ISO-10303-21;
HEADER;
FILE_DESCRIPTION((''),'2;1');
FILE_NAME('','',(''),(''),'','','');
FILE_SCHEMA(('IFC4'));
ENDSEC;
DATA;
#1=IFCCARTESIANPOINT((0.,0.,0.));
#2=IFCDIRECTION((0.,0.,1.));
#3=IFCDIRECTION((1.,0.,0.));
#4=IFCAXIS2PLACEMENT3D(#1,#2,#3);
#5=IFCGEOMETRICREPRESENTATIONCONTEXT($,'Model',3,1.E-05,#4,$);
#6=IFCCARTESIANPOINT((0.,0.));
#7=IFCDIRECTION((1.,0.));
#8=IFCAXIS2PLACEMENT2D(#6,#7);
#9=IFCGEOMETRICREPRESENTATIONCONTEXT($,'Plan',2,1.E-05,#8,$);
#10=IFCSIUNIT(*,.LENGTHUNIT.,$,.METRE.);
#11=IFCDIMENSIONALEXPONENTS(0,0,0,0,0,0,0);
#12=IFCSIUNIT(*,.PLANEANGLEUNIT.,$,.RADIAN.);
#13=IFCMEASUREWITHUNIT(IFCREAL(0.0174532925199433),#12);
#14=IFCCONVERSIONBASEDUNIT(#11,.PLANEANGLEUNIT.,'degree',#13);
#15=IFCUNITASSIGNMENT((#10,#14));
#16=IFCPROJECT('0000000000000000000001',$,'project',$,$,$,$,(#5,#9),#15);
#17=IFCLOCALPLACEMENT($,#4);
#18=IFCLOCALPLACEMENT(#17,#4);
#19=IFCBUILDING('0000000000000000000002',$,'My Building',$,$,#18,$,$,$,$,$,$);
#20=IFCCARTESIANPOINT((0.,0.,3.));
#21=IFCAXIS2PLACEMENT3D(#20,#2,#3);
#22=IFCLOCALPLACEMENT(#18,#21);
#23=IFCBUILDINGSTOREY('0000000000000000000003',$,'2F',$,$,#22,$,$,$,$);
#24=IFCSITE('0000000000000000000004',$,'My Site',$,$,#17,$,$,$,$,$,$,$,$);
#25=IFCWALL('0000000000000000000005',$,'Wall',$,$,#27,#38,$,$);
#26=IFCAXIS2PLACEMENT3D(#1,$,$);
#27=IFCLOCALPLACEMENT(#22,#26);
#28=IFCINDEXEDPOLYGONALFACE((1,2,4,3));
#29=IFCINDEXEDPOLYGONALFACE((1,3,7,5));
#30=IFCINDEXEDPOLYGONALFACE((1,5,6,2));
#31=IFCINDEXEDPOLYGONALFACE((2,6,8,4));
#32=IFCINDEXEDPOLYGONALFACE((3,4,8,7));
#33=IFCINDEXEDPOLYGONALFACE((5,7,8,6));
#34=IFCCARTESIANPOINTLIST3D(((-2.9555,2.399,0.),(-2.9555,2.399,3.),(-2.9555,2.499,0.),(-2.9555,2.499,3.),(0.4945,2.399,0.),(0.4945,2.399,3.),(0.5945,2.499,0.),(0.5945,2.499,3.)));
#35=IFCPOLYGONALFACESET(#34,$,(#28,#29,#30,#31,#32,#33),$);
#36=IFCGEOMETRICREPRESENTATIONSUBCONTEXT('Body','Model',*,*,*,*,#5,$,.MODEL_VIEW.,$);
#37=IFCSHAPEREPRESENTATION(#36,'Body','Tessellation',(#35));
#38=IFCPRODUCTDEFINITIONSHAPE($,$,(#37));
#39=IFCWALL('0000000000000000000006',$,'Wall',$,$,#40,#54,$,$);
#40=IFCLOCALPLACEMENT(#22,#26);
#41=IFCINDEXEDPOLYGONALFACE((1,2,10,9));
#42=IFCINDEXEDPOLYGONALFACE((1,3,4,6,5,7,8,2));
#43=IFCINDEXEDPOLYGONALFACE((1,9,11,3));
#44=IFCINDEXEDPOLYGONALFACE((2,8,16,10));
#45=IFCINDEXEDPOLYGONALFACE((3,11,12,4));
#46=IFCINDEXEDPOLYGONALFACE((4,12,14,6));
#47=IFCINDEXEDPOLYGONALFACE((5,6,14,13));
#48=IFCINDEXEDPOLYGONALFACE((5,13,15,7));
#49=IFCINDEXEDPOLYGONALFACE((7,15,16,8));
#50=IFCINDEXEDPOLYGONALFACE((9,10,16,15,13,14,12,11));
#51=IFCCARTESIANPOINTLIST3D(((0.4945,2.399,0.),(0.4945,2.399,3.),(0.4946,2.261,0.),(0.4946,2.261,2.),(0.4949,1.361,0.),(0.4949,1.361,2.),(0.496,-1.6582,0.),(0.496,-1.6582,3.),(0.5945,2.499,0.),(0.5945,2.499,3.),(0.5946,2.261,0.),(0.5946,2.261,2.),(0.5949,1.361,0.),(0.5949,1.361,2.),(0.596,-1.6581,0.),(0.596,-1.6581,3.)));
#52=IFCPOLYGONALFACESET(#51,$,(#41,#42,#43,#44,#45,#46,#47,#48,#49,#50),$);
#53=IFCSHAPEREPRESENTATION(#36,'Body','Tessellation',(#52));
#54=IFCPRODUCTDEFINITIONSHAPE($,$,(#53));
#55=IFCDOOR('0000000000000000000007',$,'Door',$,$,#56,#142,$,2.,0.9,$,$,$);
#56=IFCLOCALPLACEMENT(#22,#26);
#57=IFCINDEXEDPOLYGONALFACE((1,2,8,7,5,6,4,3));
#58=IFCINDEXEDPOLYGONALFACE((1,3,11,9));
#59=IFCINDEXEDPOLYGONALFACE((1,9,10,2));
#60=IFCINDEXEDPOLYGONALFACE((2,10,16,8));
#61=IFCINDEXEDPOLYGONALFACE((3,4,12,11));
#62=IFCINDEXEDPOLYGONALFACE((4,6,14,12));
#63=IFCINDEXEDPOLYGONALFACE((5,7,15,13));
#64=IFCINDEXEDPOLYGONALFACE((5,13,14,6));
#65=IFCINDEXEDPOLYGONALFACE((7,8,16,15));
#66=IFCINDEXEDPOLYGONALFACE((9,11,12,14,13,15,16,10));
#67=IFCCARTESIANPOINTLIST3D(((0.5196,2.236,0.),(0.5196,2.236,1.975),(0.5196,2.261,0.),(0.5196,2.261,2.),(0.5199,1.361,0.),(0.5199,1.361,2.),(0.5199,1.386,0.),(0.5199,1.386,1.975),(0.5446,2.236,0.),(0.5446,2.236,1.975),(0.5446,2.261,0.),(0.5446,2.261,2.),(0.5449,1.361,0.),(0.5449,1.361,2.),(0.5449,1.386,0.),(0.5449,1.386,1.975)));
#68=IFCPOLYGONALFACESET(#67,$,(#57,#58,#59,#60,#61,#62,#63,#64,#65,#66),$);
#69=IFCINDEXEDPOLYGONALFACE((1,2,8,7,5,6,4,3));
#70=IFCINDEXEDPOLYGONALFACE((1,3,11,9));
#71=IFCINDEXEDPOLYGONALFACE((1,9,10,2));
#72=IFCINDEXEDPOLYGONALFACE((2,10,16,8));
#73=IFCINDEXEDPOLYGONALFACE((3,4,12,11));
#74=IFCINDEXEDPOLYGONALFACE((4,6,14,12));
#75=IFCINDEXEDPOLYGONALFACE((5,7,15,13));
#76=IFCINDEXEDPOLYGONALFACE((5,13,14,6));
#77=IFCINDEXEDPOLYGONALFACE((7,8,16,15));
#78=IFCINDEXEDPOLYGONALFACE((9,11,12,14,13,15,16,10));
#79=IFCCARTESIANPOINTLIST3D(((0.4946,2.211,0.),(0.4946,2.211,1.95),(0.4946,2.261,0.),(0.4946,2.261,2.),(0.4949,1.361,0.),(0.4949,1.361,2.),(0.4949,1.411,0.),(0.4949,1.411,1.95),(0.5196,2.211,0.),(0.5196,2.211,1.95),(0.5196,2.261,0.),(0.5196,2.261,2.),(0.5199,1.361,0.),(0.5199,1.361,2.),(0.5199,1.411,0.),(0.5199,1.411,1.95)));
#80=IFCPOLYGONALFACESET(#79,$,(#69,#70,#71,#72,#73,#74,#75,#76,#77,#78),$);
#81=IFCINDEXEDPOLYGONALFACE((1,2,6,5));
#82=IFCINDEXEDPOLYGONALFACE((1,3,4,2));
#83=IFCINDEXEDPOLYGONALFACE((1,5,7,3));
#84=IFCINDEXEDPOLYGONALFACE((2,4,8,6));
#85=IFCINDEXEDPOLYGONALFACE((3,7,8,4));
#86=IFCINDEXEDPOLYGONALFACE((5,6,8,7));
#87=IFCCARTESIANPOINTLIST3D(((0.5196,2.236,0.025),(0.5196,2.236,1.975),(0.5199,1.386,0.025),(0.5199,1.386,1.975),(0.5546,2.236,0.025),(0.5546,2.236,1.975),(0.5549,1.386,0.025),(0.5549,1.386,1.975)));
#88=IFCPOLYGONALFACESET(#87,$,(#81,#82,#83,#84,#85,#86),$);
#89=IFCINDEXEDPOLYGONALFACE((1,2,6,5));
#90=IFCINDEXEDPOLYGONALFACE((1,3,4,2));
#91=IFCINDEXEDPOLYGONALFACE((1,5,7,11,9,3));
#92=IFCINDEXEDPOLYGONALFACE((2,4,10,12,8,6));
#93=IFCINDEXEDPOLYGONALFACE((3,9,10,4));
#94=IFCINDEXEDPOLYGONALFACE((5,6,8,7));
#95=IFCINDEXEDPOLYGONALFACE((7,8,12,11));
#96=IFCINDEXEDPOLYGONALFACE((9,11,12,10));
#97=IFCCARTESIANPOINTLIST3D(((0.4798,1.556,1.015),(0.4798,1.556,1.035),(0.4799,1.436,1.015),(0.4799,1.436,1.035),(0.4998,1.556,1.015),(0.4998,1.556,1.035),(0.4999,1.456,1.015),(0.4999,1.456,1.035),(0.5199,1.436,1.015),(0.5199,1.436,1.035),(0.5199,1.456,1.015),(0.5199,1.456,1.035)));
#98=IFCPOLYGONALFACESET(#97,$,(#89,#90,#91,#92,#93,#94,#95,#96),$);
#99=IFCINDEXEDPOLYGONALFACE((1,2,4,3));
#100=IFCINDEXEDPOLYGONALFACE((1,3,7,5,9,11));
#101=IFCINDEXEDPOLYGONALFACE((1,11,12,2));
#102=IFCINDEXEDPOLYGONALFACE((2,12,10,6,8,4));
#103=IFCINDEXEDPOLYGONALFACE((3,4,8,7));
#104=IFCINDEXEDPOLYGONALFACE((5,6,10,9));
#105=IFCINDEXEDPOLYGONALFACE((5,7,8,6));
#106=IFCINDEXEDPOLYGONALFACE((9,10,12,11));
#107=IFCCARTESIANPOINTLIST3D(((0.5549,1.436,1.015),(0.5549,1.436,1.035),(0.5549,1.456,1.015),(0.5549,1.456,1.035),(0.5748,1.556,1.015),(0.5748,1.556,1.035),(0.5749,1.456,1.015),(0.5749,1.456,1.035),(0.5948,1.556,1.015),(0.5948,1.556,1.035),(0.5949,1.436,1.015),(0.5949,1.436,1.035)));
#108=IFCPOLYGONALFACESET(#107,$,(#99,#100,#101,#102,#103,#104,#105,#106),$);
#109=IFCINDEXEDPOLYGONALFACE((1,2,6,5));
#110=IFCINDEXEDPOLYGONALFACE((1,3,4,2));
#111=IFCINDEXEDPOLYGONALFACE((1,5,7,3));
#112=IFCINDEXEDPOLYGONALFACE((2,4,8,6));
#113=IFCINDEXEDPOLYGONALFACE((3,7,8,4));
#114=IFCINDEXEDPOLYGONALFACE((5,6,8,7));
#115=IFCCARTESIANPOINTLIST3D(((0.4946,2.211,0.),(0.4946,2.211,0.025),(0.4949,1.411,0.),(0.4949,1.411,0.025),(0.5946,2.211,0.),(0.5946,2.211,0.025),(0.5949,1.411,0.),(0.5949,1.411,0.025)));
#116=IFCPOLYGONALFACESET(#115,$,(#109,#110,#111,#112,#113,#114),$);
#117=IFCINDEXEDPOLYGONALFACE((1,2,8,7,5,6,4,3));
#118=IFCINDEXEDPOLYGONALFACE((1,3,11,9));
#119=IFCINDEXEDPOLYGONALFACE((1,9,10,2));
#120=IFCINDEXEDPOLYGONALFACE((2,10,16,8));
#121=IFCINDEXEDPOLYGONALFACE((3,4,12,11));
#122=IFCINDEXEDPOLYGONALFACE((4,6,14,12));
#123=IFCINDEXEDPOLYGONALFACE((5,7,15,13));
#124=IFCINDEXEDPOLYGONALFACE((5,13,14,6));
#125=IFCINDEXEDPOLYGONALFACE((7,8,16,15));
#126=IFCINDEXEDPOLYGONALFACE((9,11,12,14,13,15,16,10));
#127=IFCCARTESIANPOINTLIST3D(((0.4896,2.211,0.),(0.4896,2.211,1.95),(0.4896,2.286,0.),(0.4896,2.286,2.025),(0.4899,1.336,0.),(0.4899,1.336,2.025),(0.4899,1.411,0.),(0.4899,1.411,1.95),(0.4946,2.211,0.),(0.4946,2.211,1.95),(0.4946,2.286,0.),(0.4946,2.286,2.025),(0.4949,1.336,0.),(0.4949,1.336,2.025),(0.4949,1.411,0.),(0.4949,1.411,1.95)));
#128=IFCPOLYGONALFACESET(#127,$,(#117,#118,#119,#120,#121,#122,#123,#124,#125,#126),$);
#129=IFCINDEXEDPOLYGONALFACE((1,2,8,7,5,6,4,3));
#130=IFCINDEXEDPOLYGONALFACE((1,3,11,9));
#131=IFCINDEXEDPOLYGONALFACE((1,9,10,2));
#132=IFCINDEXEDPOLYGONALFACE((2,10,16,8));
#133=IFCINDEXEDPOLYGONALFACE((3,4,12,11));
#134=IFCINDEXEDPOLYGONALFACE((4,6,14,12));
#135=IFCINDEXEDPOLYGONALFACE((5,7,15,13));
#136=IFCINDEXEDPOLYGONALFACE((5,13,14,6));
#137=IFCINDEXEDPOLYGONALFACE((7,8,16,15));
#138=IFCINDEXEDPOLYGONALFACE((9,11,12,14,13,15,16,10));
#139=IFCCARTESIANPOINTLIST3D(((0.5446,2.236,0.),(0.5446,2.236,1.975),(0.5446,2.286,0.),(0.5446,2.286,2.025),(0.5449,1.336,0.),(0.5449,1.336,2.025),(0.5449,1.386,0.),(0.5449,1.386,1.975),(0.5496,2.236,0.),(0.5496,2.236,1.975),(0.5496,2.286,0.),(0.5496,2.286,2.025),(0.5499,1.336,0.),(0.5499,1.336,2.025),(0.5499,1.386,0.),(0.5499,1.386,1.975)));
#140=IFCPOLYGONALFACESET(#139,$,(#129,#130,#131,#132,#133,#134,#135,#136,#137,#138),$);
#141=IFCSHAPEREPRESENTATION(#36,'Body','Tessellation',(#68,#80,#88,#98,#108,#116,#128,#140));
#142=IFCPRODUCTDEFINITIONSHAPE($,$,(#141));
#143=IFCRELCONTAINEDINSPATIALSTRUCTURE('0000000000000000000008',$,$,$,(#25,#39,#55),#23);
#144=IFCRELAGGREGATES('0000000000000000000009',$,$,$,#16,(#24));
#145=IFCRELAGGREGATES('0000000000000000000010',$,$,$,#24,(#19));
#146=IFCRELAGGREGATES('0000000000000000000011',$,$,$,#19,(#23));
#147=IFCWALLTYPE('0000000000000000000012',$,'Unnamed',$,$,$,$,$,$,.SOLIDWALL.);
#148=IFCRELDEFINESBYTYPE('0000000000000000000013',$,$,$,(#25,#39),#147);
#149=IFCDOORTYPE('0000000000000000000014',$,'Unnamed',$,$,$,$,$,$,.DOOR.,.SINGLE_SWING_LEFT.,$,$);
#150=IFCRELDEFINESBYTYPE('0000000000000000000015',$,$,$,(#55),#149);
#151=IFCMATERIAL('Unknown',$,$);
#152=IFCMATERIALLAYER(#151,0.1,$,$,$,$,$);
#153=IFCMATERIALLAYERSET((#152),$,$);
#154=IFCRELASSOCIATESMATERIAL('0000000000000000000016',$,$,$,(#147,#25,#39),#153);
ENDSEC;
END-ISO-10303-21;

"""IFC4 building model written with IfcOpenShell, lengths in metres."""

from ifc_helpers import new_model, entity, si_unit, converted_unit, frame, origin_with_axes, origin_2d_with_axis, place, context, subcontext, project, spatial, line, indexed_curve, outline, extrude, shape, source, transform, mapped, material, layer, layer_set, layer_usage, type_object, type_shapes, element, fill, save


model = new_model("IFC4")

# Units and contexts
model_context = context("Model", 3, precision=1e-05, world=origin_with_axes())
plan_context = context("Plan", 2, precision=1e-05, world=origin_2d_with_axis())
body_context_1 = subcontext(model_context, "Body", "Model", "MODEL_VIEW")
body_context_2 = subcontext(plan_context, "Body", "Plan", "PLAN_VIEW")
ifc_project = project(units=[si_unit("LENGTHUNIT", "METRE"), converted_unit("PLANEANGLEUNIT", "degree", entity("IfcReal", 0.0174532925199433), si_unit("PLANEANGLEUNIT", "RADIAN"), dimensions=[0, 0, 0, 0, 0, 0, 0])], contexts=[model_context, plan_context])

# Site, building, storey
site_placement = place(None, origin_with_axes())
site = spatial("IfcSite", under=ifc_project, at=site_placement, Name="My Site")
building_placement = place(site_placement, origin_with_axes())
building = spatial("IfcBuilding", under=site, at=building_placement, Name="My Building")
storey_placement = place(building_placement, frame((0.0, 0.0, 3.0), z_axis=(0.0, 0.0, 1.0), x_axis=(1.0, 0.0, 0.0)))
storey = spatial("IfcBuildingStorey", under=building, at=storey_placement, Name="2F")

# Shared definitions
ifc_material = material(Name="Unknown")

# Wall
ifc_layer = layer(ifc_material, 0.1)
ifc_layer_set = layer_set([ifc_layer])
ifc_layer_usage_1 = layer_usage(ifc_layer_set, "AXIS2", "POSITIVE", 0.0)
wall_type = type_object("IfcWallType", Name="Unnamed", PredefinedType="SOLIDWALL", material=ifc_layer_set)
wall_1_placement = place(storey_placement, frame((-2.9555, 2.399, 0.0), z_axis=(0.0, 0.0, 1.0), x_axis=(1.0, 0.0, 0.0)))
element("IfcWall", 1, at=wall_1_placement, inside=storey, type_object=wall_type, material=ifc_layer_usage_1, Name="Wall", context=body_context_1, shape_type="SweptSolid", body=[
    extrude(outline(indexed_curve([(0.0, 0.0), (0.0, 0.1), (3.55, 0.1), (3.45, 0.0)], segments=[line(1, 2, 3, 4, 1)])), origin_with_axes(), (0.0, 0.0, 1.0), 3.0),
])

# Wall, opening, door
ifc_layer_usage_2 = layer_usage(ifc_layer_set, "AXIS2", "POSITIVE", 0.0)
wall_2_placement = place(storey_placement, frame((0.4945, 2.399, 0.0), z_axis=(0.0, 0.0, 1.0), x_axis=(0.000374, -1.0, 0.0)))
wall_2 = element("IfcWall", 2, at=wall_2_placement, inside=storey, type_object=wall_type, material=ifc_layer_usage_2, Name="Wall", context=body_context_1, shape_type="SweptSolid", body=[
    extrude(outline(indexed_curve([(0.0, 0.0), (-0.1, 0.1), (4.0571, 0.1), (4.0571, 0.0)], segments=[line(1, 2, 3, 4, 1)])), origin_with_axes(), (0.0, 0.0, 1.0), 3.0),
])
shared_shape_1 = source(origin_with_axes(), body_context_1, "Body", "SweptSolid", [
    extrude(outline(indexed_curve([(0.0, 0.0), (0.9, 0.0), (0.9, 2.0), (0.0, 2.0)], segments=[line(1, 2, 3, 4, 1)])), frame((0.0, -0.6, 0.0), z_axis=(0.0, -1.0, 0.0), x_axis=(1.0, 0.0, 0.0)), (0.0, 0.0, -1.0), 1.2),
])
opening_1_placement = place(wall_2_placement, frame((0.138, 0.0, 0.0), z_axis=(0.0, 0.0, 1.0), x_axis=(1.0, 0.0, 0.0)))
opening_1 = element("IfcOpeningElement", 3, at=opening_1_placement, cuts=wall_2, PredefinedType="OPENING", context=body_context_1, shape_type="MappedRepresentation", body=[
    mapped(shared_shape_1, transform((0.0, 0.0, 0.0), x_axis=(1.0, 0.0, 0.0), y_axis=(0.0, 1.0, 0.0), z_axis=(0.0, 0.0, 1.0), scale=1.0)),
])
door_type_1 = type_object("IfcDoorType", Name="Unnamed", OperationType="SINGLE_SWING_LEFT", PredefinedType="DOOR")
shared_shape_2 = source(origin_with_axes(), body_context_1, "Body", "SweptSolid", [
    extrude(outline(indexed_curve([(0.0, 0.0), (0.0, 2.0), (0.9, 2.0), (0.9, 0.0), (0.875, 0.0), (0.875, 1.975), (0.025, 1.975), (0.025, 0.0)], segments=[line(1, 2, 3, 4, 5, 6, 7, 8, 1)])), frame((0.0, 0.025, 0.0), z_axis=(0.0, -1.0, 0.0), x_axis=(1.0, 0.0, 0.0)), (0.0, 0.0, -1.0), 0.025),
    extrude(outline(indexed_curve([(0.0, 0.0), (0.0, 2.0), (0.9, 2.0), (0.9, 0.0), (0.85, 0.0), (0.85, 1.95), (0.05, 1.95), (0.05, 0.0)], segments=[line(1, 2, 3, 4, 5, 6, 7, 8, 1)])), frame((0.0, 0.0, 0.0), z_axis=(0.0, -1.0, 0.0), x_axis=(1.0, 0.0, 0.0)), (0.0, 0.0, -1.0), 0.025),
    extrude(outline(indexed_curve([(0.0, 0.0), (0.85, 0.0), (0.85, 0.035), (0.0, 0.035)], segments=[line(1, 2, 3, 4, 1)])), frame((0.025, 0.025, 0.025), z_axis=(0.0, 0.0, 1.0), x_axis=(1.0, 0.0, 0.0)), (0.0, 0.0, 1.0), 1.95),
    extrude(outline(indexed_curve([(0.0, 0.0), (0.0, -0.04), (-0.12, -0.04), (-0.12, -0.02), (-0.02, -0.02), (-0.02, 0.0)], segments=[line(1, 2, 3, 4, 5, 6, 1)])), frame((0.825, 0.025, 1.015), z_axis=(0.0, 0.0, 1.0), x_axis=(1.0, 0.0, 0.0)), (0.0, 0.0, 1.0), 0.02),
    extrude(outline(indexed_curve([(0.0, 0.0), (0.0, 0.04), (-0.12, 0.04), (-0.12, 0.02), (-0.02, 0.02), (-0.02, 0.0)], segments=[line(1, 2, 3, 4, 5, 6, 1)])), frame((0.825, 0.06, 1.015), z_axis=(0.0, 0.0, 1.0), x_axis=(1.0, 0.0, 0.0)), (0.0, 0.0, 1.0), 0.02),
    extrude(outline(indexed_curve([(0.0, 0.0), (0.8, 0.0), (0.8, 0.1), (0.0, 0.1)], segments=[line(1, 2, 3, 4, 1)])), frame((0.05, 0.0, 0.0), z_axis=(0.0, 0.0, 1.0), x_axis=(1.0, 0.0, 0.0)), (0.0, 0.0, 1.0), 0.025),
    extrude(outline(indexed_curve([(0.0, 0.0), (0.0, 2.025), (0.95, 2.025), (0.95, 0.0), (0.875, 0.0), (0.875, 1.95), (0.075, 1.95), (0.075, 0.0)], segments=[line(1, 2, 3, 4, 5, 6, 7, 8, 1)])), frame((-0.025, -0.005, 0.0), z_axis=(0.0, -1.0, 0.0), x_axis=(1.0, 0.0, 0.0)), (0.0, 0.0, -1.0), 0.005),
    extrude(outline(indexed_curve([(0.0, 0.0), (0.0, 2.025), (0.95, 2.025), (0.95, 0.0), (0.9, 0.0), (0.9, 1.975), (0.05, 1.975), (0.05, 0.0)], segments=[line(1, 2, 3, 4, 5, 6, 7, 8, 1)])), frame((-0.025, 0.05, 0.0), z_axis=(0.0, -1.0, 0.0), x_axis=(1.0, 0.0, 0.0)), (0.0, 0.0, -1.0), 0.005),
])
shared_shape_3 = source(origin_with_axes(), body_context_2, "Body", "Curve2D", [
    entity("IfcIndexedPolyCurve", entity("IfcCartesianPointList2D", [[0.0, 0.0], [0.0, 0.05], [0.025, 0.05], [0.025, 0.025], [0.05, 0.025], [0.05, 0.0]]), [entity("IfcLineIndex", [1, 2, 3, 4, 5, 6, 1])]),
    entity("IfcIndexedPolyCurve", entity("IfcCartesianPointList2D", [[0.9, 0.0], [0.9, 0.05], [0.875, 0.05], [0.875, 0.025], [0.85, 0.025], [0.85, 0.0]]), [entity("IfcLineIndex", [1, 2, 3, 4, 5, 6, 1])]),
    entity("IfcTrimmedCurve", entity("IfcEllipse", entity("IfcAxis2Placement2D", entity("IfcCartesianPoint", [0.06, 0.05]), entity("IfcDirection", [1.0, 0.0])), 0.815, 0.85), [entity("IfcCartesianPoint", [0.875, 0.05])], [entity("IfcCartesianPoint", [0.06, 0.9])], True, "CARTESIAN"),
    entity("IfcIndexedPolyCurve", entity("IfcCartesianPointList2D", [[0.025, 0.05], [0.06, 0.05], [0.06, 0.9], [0.025, 0.9]]), [entity("IfcLineIndex", [1, 2, 3, 4, 1])]),
])
type_shapes(door_type_1, [shared_shape_2, shared_shape_3])
door_1_placement = place(opening_1_placement, frame((0.0, 0.0, 0.0), z_axis=(0.0, 0.0, 1.0), x_axis=(1.0, 0.0, 0.0)))
door_1 = element("IfcDoor", 4, at=door_1_placement, inside=storey, type_object=door_type_1, Name="Door", OverallHeight=2.0, OverallWidth=0.9, shapes=[
    shape(body_context_1, "Body", "MappedRepresentation", [mapped(shared_shape_2, transform((0.0, 0.0, 0.0), x_axis=(1.0, 0.0, 0.0), y_axis=(0.0, 1.0, 0.0), z_axis=(0.0, 0.0, 1.0), scale=1.0))]),
    shape(body_context_2, "Body", "MappedRepresentation", [mapped(shared_shape_3, transform((0.0, 0.0, 0.0), x_axis=(1.0, 0.0, 0.0), y_axis=(0.0, 1.0, 0.0), z_axis=(0.0, 0.0, 1.0), scale=1.0))]),
])
fill(opening_1, door_1)

save(model, "model.ifc")
